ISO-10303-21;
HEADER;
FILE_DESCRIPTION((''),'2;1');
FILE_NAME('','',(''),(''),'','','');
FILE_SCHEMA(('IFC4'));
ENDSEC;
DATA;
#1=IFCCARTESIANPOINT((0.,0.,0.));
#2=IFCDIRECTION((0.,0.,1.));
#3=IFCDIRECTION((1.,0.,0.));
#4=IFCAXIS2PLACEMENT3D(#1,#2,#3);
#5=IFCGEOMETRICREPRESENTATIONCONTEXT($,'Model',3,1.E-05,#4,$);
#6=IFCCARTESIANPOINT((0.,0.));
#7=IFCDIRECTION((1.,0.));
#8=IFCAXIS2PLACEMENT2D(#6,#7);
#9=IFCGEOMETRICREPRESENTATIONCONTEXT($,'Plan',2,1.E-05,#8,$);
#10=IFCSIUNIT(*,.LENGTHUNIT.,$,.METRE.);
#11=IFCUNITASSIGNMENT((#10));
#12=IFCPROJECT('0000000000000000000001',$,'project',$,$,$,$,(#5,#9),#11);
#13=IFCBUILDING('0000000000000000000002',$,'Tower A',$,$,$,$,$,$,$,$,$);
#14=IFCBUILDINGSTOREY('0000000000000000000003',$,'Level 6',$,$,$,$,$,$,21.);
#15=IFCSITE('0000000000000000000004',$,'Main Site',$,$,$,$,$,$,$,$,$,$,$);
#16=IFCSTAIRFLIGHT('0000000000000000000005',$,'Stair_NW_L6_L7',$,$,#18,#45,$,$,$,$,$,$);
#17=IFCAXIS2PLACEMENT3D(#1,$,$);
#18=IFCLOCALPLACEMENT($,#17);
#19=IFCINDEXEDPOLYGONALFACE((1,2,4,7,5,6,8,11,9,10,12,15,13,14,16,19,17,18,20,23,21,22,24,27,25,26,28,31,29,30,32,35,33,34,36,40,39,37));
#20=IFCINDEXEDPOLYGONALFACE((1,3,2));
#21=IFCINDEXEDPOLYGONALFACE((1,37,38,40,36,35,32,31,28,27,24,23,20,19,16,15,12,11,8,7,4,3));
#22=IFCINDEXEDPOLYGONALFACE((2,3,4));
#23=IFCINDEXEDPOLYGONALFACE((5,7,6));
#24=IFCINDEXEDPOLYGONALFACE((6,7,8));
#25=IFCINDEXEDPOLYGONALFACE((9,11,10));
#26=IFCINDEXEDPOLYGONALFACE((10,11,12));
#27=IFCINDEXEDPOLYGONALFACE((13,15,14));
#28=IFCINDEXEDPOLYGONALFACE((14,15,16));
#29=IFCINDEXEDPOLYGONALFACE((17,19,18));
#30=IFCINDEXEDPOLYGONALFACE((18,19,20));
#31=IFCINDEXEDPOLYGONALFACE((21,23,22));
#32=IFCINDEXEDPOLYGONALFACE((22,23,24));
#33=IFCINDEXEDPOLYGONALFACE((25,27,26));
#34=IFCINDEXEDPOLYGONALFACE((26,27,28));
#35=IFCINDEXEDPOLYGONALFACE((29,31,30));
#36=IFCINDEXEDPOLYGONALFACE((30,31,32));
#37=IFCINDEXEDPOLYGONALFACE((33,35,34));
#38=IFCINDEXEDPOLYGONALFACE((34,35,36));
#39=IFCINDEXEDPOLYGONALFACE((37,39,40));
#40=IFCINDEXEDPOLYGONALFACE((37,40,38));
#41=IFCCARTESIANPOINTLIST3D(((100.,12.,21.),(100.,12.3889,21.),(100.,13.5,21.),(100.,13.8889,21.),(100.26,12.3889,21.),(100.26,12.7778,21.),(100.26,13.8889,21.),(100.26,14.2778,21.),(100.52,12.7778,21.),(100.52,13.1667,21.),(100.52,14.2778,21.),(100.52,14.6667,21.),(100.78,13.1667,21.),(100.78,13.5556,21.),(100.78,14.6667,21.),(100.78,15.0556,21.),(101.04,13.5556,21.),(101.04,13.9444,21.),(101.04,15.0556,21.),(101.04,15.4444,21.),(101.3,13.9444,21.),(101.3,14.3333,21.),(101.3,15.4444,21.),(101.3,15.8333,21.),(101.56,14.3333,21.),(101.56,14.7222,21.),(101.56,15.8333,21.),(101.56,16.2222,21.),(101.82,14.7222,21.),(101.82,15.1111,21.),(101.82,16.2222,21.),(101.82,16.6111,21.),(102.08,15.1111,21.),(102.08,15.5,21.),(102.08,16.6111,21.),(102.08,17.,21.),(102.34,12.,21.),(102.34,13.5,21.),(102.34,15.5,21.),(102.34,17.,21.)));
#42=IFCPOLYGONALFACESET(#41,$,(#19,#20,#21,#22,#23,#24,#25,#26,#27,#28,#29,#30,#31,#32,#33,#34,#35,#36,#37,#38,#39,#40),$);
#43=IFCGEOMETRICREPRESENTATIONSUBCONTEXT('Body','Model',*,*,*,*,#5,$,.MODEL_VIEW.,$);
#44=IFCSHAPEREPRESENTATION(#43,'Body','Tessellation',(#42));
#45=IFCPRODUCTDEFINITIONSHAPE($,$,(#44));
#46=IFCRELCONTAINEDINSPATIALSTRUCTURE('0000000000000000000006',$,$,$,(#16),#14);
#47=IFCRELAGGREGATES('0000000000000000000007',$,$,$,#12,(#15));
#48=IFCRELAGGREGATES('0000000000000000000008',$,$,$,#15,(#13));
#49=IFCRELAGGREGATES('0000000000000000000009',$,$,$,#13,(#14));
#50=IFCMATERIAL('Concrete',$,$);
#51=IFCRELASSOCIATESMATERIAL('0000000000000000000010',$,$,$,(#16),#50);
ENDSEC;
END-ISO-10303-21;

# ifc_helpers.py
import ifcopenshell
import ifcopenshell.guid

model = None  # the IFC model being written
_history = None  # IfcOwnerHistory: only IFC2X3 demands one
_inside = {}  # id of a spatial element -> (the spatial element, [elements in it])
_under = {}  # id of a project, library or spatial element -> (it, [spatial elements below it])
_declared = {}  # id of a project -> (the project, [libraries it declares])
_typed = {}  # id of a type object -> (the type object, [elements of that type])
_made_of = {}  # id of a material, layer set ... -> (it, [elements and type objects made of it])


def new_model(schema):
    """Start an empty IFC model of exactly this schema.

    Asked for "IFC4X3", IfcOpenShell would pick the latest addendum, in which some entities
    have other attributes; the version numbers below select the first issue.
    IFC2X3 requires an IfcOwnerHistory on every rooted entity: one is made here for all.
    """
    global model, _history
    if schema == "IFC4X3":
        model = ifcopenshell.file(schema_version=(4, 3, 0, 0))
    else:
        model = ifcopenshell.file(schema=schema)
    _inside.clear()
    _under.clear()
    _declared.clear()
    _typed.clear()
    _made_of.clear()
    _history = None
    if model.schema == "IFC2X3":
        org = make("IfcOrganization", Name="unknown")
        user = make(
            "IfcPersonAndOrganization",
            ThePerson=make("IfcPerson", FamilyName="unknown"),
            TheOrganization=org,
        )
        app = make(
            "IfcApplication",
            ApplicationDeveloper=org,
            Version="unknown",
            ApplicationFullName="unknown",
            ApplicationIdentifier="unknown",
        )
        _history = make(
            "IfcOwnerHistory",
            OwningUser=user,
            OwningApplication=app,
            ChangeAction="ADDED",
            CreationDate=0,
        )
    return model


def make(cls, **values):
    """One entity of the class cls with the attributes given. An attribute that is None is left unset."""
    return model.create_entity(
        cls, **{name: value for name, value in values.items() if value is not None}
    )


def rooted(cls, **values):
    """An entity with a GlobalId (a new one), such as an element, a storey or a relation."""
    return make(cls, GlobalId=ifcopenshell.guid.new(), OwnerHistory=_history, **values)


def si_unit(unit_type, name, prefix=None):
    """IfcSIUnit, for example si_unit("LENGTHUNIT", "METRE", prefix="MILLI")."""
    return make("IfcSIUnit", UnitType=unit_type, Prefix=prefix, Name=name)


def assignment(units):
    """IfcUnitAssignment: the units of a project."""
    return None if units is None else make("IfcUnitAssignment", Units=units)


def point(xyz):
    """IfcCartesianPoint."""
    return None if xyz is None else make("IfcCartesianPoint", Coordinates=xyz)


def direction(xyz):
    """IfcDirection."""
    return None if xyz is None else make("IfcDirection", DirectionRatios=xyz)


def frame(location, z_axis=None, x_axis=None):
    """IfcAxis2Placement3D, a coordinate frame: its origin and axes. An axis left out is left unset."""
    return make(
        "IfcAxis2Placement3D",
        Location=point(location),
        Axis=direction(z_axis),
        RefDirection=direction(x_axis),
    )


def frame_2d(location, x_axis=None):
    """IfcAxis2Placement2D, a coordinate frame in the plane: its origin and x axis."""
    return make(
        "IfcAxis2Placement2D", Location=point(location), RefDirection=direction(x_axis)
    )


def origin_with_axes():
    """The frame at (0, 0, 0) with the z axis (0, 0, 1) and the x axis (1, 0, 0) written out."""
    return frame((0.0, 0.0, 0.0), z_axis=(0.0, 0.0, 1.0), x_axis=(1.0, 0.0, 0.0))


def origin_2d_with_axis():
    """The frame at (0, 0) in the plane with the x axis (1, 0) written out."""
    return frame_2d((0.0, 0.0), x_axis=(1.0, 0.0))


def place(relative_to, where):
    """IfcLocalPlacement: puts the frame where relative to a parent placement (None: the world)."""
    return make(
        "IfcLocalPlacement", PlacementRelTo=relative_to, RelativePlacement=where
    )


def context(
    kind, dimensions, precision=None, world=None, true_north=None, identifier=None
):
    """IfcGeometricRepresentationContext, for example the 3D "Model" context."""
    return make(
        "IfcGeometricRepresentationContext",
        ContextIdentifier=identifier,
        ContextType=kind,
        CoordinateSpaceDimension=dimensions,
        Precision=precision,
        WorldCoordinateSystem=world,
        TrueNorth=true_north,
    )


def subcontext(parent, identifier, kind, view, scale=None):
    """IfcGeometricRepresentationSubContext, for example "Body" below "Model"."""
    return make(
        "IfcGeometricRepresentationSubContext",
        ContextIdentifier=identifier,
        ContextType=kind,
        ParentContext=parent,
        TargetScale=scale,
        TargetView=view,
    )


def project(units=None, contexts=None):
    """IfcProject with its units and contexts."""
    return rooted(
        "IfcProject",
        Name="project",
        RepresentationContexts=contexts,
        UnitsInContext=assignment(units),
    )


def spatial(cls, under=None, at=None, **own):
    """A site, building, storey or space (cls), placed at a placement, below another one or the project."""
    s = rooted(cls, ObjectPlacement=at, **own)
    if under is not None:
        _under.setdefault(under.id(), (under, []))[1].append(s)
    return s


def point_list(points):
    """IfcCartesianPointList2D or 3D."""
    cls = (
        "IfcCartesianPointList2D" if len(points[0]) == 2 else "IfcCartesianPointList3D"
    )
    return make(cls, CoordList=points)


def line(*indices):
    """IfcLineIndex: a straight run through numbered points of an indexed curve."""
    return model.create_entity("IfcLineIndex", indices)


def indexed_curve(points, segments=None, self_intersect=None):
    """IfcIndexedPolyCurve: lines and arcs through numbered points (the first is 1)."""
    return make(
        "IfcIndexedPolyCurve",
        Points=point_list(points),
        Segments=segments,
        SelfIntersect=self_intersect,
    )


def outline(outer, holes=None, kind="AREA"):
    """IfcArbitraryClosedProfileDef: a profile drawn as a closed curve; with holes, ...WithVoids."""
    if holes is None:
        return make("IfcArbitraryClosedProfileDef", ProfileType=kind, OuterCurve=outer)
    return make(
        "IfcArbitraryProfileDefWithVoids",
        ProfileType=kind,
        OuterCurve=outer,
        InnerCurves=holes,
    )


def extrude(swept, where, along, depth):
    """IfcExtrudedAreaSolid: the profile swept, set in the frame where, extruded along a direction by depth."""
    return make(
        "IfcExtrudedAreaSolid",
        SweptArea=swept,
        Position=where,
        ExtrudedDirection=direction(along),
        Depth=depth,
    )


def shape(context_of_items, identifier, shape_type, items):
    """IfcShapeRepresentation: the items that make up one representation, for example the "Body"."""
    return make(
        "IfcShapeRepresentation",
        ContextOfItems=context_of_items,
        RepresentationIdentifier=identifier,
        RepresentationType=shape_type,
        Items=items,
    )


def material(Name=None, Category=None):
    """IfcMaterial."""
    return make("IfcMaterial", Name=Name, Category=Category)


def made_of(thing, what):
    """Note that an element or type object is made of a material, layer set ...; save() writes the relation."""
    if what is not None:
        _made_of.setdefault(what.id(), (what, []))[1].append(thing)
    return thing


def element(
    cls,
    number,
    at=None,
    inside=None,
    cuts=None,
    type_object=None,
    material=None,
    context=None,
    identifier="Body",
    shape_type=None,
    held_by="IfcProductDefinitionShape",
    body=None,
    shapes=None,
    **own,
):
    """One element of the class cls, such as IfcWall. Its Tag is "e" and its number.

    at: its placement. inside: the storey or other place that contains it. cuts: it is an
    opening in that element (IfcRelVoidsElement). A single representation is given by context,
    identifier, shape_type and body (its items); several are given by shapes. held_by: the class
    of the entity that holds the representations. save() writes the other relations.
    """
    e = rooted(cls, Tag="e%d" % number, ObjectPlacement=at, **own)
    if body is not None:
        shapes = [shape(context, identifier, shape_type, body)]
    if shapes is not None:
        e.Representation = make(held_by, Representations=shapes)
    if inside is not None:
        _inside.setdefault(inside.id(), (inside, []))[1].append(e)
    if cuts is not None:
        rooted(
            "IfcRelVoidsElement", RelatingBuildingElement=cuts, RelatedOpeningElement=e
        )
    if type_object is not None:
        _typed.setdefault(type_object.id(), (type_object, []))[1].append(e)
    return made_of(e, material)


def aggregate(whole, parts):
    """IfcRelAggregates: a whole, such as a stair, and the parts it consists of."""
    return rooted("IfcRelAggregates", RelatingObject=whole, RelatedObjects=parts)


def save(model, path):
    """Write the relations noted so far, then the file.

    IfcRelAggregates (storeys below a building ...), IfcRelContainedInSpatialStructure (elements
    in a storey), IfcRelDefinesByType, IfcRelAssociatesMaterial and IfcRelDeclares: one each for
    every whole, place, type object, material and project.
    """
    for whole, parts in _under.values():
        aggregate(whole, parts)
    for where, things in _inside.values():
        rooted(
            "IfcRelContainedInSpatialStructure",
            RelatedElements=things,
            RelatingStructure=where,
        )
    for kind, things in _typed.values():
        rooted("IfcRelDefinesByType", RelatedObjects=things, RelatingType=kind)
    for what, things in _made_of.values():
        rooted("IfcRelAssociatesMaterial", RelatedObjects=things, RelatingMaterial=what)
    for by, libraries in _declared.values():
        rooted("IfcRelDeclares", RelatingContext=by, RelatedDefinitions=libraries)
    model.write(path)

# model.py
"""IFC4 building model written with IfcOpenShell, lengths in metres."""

from ifc_helpers import new_model, si_unit, frame, origin_with_axes, origin_2d_with_axis, place, context, subcontext, project, spatial, line, indexed_curve, outline, extrude, material, element, save


model = new_model("IFC4")

# Units and contexts
model_context = context("Model", 3, precision=1e-05, world=origin_with_axes())
plan_context = context("Plan", 2, precision=1e-05, world=origin_2d_with_axis())
body_context = subcontext(model_context, "Body", "Model", "MODEL_VIEW")
ifc_project = project(units=[si_unit("LENGTHUNIT", "METRE")], contexts=[model_context, plan_context])

# Site, building, storey
site = spatial("IfcSite", under=ifc_project, Name="Main Site")
building = spatial("IfcBuilding", under=site, Name="Tower A")
storey = spatial("IfcBuildingStorey", under=building, Name="Level 6", Elevation=21.0)

# Stair flight
ifc_material_1 = material(Name="Concrete")
stair_flight_placement = place(None, frame((100.0, 12.0, 21.0), z_axis=(0.0, 0.0, 1.0), x_axis=(1.0, 0.0, 0.0)))
element("IfcStairFlight", 1, at=stair_flight_placement, inside=storey, material=ifc_material_1, Name="Stair_NW_L6_L7", context=body_context, shape_type="SweptSolid", body=[
    extrude(outline(indexed_curve([(0.0, 0.0), (0.0, 0.3889), (0.26, 0.3889), (0.26, 0.7778), (0.52, 0.7778), (0.52, 1.1667), (0.78, 1.1667), (0.78, 1.5556), (1.04, 1.5556), (1.04, 1.9444), (1.3, 1.9444), (1.3, 2.3333), (1.56, 2.3333), (1.56, 2.7222), (1.82, 2.7222), (1.82, 3.1111), (2.08, 3.1111), (2.08, 3.5), (2.34, 3.5), (2.34, 0.0)], segments=[line(1, 2, 3, 4, 5, 6, 7, 8, 9, 10, 11, 12, 13, 14, 15, 16, 17, 18, 19, 20, 1)])), origin_with_axes(), (0.0, 1.0, 0.0), 1.5),
])

save(model, "model.ifc")
